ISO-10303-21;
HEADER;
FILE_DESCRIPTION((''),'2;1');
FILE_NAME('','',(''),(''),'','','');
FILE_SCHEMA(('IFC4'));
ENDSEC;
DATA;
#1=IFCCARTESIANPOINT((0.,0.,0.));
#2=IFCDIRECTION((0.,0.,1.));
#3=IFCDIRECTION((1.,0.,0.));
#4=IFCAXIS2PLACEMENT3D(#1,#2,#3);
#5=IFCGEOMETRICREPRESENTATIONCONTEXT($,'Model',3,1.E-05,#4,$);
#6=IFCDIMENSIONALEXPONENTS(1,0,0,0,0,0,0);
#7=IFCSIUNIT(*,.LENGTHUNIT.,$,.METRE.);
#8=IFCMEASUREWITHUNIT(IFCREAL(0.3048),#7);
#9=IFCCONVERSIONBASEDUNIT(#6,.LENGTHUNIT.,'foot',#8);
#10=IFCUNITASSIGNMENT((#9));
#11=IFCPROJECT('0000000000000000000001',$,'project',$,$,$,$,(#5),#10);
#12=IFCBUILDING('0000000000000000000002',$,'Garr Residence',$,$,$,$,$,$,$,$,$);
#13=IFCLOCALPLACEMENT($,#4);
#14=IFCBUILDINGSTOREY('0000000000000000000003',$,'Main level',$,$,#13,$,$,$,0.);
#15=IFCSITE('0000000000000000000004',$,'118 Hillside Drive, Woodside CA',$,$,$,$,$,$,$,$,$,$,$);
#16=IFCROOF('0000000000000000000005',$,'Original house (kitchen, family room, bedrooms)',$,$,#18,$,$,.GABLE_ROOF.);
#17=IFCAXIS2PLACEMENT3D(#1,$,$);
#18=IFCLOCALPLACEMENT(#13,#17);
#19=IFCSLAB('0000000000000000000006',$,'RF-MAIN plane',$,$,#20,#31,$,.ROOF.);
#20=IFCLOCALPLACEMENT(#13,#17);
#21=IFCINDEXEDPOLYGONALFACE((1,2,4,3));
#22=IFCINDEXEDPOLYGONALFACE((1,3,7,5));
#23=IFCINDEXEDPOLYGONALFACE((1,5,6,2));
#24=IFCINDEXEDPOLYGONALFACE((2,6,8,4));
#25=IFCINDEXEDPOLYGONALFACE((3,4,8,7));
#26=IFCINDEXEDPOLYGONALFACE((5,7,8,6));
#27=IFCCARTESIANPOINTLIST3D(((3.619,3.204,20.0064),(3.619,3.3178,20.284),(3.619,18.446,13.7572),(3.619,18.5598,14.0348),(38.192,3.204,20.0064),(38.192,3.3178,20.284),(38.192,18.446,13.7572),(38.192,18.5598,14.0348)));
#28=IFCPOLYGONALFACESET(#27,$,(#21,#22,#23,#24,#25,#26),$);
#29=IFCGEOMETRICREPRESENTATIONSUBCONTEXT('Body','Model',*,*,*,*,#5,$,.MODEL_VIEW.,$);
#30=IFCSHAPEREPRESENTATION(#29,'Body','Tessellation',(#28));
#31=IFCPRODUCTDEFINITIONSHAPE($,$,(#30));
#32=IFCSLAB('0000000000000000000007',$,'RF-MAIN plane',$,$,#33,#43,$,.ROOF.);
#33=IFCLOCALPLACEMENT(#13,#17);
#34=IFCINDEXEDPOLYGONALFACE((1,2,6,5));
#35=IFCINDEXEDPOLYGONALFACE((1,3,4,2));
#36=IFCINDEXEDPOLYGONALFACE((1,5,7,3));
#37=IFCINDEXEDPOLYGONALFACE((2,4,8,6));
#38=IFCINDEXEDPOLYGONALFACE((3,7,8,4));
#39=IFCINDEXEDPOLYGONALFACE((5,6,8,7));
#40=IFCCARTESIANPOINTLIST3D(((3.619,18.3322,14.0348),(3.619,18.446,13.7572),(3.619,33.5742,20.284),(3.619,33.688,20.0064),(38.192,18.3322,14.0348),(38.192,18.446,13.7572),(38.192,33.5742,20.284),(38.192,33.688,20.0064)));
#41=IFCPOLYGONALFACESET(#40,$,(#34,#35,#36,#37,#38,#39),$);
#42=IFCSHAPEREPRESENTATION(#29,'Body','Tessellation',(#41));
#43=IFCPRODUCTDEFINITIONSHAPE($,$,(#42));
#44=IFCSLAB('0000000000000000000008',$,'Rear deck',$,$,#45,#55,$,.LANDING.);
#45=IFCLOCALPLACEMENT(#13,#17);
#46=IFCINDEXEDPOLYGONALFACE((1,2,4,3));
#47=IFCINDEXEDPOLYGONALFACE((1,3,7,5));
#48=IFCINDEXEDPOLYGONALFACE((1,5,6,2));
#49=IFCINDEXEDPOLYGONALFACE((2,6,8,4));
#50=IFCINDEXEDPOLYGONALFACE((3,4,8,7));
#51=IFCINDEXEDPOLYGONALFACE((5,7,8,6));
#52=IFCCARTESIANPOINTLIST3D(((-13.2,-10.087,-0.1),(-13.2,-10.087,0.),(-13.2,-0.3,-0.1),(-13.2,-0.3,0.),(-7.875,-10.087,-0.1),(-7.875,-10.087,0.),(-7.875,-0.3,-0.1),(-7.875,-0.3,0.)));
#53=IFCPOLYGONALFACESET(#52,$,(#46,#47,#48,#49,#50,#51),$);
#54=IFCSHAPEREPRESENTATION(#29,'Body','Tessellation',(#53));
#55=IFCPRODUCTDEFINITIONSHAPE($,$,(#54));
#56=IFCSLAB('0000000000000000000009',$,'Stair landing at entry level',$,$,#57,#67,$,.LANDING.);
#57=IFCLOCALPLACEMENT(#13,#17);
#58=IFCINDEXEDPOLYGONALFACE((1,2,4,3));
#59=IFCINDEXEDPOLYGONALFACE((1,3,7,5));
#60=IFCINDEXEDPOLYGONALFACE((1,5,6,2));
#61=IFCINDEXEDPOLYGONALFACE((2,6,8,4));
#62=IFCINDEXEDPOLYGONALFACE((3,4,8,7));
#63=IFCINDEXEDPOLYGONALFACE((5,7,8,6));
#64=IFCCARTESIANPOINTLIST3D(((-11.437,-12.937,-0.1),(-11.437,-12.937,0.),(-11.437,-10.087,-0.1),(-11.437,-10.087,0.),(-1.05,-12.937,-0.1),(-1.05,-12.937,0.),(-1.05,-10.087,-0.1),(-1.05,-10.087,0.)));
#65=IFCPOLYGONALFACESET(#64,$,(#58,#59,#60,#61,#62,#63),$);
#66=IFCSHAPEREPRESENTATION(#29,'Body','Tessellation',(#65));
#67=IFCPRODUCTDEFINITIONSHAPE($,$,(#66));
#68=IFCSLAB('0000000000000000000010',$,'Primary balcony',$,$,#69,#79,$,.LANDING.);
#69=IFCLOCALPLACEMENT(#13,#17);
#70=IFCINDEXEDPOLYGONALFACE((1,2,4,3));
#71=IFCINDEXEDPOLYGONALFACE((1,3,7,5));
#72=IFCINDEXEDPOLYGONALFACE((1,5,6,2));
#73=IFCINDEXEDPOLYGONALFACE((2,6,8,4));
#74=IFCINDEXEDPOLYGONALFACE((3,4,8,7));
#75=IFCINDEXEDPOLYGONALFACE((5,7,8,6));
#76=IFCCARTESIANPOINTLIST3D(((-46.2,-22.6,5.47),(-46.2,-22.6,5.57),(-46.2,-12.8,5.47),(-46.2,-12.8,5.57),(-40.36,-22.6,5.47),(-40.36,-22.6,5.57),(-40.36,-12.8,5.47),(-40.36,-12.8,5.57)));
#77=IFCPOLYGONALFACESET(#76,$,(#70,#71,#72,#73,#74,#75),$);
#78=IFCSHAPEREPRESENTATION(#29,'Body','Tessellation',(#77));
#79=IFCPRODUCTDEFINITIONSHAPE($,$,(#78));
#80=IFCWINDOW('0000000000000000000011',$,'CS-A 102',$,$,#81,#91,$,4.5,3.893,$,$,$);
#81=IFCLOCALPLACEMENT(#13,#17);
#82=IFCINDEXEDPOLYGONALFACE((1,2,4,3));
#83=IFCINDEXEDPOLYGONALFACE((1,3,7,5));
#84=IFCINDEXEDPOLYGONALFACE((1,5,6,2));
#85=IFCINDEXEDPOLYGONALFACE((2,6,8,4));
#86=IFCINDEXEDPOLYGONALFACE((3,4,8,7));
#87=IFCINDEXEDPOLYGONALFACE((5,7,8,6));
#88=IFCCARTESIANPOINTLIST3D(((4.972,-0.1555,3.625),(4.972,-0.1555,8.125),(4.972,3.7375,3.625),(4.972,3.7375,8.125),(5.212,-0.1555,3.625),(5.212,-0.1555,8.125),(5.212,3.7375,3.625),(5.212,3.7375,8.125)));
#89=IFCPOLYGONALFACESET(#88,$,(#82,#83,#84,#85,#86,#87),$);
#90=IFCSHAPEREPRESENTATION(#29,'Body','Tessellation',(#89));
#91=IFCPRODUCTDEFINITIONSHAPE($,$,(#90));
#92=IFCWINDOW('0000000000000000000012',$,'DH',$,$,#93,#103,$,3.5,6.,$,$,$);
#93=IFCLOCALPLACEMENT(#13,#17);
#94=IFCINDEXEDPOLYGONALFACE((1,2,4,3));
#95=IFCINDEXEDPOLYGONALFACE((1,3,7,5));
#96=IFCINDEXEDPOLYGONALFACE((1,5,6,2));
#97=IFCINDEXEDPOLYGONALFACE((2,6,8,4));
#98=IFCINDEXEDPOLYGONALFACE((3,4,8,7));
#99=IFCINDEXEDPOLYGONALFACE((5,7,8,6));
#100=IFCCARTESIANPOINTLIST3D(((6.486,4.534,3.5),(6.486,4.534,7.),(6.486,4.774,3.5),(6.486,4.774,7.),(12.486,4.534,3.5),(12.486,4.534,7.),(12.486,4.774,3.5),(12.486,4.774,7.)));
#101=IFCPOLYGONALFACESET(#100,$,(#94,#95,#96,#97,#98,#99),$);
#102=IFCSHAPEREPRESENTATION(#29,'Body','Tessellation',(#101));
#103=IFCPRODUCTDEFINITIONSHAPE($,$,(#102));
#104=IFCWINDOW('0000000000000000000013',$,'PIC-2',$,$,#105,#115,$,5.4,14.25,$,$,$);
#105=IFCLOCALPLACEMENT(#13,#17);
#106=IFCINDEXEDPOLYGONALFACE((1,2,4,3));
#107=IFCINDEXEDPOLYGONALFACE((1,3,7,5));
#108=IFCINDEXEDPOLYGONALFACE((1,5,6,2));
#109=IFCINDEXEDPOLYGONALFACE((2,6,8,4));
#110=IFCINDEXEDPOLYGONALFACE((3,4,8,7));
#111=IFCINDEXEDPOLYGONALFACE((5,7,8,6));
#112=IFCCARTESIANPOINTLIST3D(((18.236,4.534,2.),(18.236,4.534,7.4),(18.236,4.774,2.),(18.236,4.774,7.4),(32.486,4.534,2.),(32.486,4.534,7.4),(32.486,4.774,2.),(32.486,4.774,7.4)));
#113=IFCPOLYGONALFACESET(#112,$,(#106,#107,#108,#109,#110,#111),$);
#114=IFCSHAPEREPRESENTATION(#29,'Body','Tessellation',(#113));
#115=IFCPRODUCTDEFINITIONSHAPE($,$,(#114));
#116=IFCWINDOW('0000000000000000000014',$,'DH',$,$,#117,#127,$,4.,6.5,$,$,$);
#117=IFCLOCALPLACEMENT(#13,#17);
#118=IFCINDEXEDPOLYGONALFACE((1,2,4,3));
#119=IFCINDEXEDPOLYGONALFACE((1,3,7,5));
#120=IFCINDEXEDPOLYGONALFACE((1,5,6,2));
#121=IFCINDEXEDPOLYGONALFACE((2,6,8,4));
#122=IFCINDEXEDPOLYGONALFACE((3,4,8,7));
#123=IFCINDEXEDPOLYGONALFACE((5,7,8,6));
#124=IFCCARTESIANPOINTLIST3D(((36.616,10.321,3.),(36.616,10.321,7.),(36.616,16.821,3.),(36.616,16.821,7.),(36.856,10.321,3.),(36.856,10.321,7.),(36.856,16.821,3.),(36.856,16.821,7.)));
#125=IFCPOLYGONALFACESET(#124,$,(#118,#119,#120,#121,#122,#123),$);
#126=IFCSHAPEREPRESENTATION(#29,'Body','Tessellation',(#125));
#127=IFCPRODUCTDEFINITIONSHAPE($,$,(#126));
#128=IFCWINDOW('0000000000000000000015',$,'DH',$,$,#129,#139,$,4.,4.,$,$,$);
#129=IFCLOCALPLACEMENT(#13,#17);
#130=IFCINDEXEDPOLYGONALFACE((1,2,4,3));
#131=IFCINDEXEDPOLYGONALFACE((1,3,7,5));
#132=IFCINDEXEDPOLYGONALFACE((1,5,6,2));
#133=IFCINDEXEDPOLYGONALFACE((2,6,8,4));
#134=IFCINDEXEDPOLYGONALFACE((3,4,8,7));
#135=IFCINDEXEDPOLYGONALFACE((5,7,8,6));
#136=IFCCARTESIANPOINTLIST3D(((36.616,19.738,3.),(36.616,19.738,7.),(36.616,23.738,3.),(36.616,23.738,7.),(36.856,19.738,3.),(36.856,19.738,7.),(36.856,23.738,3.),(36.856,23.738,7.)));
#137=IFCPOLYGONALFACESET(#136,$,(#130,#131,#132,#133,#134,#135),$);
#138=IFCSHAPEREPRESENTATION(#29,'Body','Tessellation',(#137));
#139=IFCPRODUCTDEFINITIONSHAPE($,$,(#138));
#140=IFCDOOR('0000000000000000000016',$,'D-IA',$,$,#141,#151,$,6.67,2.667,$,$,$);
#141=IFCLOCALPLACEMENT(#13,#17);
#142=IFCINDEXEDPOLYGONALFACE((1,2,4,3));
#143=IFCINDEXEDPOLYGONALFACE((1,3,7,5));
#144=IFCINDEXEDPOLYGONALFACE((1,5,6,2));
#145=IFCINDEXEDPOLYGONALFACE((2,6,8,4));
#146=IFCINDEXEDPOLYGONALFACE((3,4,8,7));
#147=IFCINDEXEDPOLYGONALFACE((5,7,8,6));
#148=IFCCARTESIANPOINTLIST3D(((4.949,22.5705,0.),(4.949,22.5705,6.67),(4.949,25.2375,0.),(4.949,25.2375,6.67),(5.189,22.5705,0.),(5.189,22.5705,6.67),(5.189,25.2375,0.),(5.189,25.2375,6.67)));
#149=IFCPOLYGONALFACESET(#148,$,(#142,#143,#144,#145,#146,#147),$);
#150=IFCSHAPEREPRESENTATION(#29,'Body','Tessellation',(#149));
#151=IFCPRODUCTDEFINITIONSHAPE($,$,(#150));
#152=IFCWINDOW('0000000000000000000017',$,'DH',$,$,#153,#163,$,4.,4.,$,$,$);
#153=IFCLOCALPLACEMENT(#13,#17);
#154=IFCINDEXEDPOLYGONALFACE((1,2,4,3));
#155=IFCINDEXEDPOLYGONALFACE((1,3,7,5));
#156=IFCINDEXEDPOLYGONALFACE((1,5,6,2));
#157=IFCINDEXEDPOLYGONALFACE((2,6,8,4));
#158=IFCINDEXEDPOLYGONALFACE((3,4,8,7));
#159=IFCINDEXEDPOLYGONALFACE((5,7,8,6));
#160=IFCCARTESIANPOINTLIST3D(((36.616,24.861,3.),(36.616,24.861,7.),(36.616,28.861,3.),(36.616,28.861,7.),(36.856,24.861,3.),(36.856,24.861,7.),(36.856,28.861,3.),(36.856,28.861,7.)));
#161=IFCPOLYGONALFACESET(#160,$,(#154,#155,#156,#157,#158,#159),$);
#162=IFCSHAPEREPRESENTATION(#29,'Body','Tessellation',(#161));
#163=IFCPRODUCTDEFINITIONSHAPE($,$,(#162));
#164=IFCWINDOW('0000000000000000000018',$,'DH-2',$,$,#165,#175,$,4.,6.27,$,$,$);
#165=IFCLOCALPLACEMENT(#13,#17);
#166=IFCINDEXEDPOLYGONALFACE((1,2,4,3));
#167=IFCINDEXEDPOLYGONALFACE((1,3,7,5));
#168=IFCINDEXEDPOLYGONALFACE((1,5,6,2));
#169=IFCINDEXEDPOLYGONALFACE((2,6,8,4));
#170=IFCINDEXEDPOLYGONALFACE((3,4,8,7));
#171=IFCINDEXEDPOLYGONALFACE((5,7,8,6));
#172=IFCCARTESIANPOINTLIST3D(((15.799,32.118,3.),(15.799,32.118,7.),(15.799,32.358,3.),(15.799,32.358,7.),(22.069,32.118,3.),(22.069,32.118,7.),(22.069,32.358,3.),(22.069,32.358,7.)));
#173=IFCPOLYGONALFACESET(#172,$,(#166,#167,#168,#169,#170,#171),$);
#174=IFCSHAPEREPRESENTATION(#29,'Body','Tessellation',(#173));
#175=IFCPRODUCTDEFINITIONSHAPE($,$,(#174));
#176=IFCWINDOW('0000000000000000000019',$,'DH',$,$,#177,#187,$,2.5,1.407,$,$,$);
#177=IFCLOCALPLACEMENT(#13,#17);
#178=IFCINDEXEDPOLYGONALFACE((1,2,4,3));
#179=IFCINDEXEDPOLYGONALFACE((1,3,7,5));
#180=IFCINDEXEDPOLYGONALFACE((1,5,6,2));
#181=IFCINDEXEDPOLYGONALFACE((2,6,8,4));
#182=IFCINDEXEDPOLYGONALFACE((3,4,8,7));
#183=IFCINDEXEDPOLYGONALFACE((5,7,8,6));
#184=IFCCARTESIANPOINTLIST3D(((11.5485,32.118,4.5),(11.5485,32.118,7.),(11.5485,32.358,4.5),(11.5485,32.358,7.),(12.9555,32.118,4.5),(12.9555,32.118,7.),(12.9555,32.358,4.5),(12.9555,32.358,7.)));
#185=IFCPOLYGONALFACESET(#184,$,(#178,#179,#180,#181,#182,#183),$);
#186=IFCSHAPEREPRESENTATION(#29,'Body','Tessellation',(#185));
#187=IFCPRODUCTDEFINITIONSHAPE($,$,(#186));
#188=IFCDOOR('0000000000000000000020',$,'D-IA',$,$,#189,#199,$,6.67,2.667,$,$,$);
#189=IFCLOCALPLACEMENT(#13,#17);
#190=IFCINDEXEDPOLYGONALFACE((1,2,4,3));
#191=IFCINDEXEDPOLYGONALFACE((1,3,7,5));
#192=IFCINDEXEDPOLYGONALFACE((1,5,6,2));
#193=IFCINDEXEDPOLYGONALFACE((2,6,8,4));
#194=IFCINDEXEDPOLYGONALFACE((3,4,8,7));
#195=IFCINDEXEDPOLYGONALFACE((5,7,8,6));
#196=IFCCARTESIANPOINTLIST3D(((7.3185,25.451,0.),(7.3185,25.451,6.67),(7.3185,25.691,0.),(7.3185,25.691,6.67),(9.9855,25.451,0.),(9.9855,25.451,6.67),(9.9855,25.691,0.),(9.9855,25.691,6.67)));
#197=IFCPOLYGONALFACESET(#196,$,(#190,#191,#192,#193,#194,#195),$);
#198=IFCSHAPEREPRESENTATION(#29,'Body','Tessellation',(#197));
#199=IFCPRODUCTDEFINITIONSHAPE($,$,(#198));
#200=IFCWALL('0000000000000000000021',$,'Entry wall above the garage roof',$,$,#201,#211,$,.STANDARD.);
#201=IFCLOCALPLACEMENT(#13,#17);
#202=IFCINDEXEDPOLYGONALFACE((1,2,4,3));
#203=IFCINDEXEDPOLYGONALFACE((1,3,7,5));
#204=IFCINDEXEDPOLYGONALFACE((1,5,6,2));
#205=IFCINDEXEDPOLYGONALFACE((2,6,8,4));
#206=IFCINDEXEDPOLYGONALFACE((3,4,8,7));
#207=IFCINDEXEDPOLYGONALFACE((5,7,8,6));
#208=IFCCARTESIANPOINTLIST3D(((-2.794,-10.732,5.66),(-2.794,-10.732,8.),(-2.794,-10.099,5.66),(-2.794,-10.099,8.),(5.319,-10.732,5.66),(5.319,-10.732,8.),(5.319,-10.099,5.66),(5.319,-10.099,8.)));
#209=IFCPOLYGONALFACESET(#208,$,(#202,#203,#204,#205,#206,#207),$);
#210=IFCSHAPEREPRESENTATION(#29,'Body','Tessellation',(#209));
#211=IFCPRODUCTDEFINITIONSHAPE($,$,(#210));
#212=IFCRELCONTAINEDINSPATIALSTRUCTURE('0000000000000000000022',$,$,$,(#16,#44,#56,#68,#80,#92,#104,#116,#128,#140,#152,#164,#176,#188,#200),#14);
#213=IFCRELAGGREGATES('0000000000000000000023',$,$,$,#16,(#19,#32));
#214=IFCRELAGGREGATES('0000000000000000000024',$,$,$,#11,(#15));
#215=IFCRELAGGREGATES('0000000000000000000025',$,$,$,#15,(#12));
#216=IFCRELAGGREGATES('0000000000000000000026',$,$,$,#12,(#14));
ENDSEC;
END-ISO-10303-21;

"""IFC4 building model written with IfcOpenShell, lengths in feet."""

from ifc_helpers import new_model, entity, si_unit, converted_unit, frame, origin, origin_with_axes, place, context, subcontext, project, spatial, polyline, outline, extrude, element, aggregate, save


model = new_model("IFC4")

# Units and contexts
model_context = context("Model", 3, precision=1e-05, world=origin_with_axes())
body_context = subcontext(model_context, "Body", "Model", "MODEL_VIEW")
ifc_project = project(units=[converted_unit("LENGTHUNIT", "foot", entity("IfcReal", 0.3048), si_unit("LENGTHUNIT", "METRE"), dimensions=[1, 0, 0, 0, 0, 0, 0])], contexts=[model_context])

# Site, building, storey
site = spatial("IfcSite", under=ifc_project, Name="118 Hillside Drive, Woodside CA")
building = spatial("IfcBuilding", under=site, Name="Garr Residence")
storey_placement = place(None, origin_with_axes())
storey = spatial("IfcBuildingStorey", under=building, at=storey_placement, Name="Main level", Elevation=0.0)

# Roof, slabs
roof = element("IfcRoof", 1, inside=storey, Name="Original house (kitchen, family room, bedrooms)", PredefinedType="GABLE_ROOF")
slab_1_placement = place(None, frame((3.619, 18.446, 13.7572), z_axis=(0.0, 0.379353, 0.925252), x_axis=(1.0, 0.0, 0.0)))
slab_1 = element("IfcSlab", 2, at=slab_1_placement, Name="RF-MAIN plane", PredefinedType="ROOF", context=body_context, shape_type="SweptSolid", body=[
    extrude(outline(polyline([(0.0, 0.0), (34.573, 0.0), (34.573, -16.4734), (0.0, -16.4734), (0.0, 0.0)])), origin(), (0.0, 0.0, 1.0), 0.3),
])
slab_2_placement = place(None, frame((3.619, 18.446, 13.7572), z_axis=(0.0, -0.379353, 0.925252), x_axis=(1.0, 0.0, 0.0)))
slab_2 = element("IfcSlab", 3, at=slab_2_placement, Name="RF-MAIN plane", PredefinedType="ROOF", context=body_context, shape_type="SweptSolid", body=[
    extrude(outline(polyline([(0.0, 0.0), (34.573, 0.0), (34.573, 16.4734), (0.0, 16.4734), (0.0, 0.0)])), origin(), (0.0, 0.0, 1.0), 0.3),
])
aggregate(roof, [slab_1, slab_2])

# Slabs
slab_3_placement = place(storey_placement, frame((0.0, 0.0, -0.1), z_axis=(0.0, 0.0, 1.0), x_axis=(1.0, 0.0, 0.0)))
element("IfcSlab", 4, at=slab_3_placement, inside=storey, Name="Rear deck", PredefinedType="LANDING", context=body_context, shape_type="SweptSolid", body=[
    extrude(outline(polyline([(-13.2, -10.087), (-7.875, -10.087), (-7.875, -0.3), (-13.2, -0.3), (-13.2, -10.087)])), origin(), (0.0, 0.0, 1.0), 0.1),
])
slab_4_placement = place(storey_placement, frame((0.0, 0.0, -0.1), z_axis=(0.0, 0.0, 1.0), x_axis=(1.0, 0.0, 0.0)))
element("IfcSlab", 5, at=slab_4_placement, inside=storey, Name="Stair landing at entry level", PredefinedType="LANDING", context=body_context, shape_type="SweptSolid", body=[
    extrude(outline(polyline([(-11.437, -12.937), (-1.05, -12.937), (-1.05, -10.087), (-11.437, -10.087), (-11.437, -12.937)])), origin(), (0.0, 0.0, 1.0), 0.1),
])
slab_5_placement = place(storey_placement, frame((0.0, 0.0, 5.47), z_axis=(0.0, 0.0, 1.0), x_axis=(1.0, 0.0, 0.0)))
element("IfcSlab", 6, at=slab_5_placement, inside=storey, Name="Primary balcony", PredefinedType="LANDING", context=body_context, shape_type="SweptSolid", body=[
    extrude(outline(polyline([(-46.2, -22.6), (-40.36, -22.6), (-40.36, -12.8), (-46.2, -12.8), (-46.2, -22.6)])), origin(), (0.0, 0.0, 1.0), 0.1),
])

# Windows
window_1_placement = place(storey_placement, frame((5.092, 1.791, 3.625), z_axis=(0.0, 0.0, 1.0), x_axis=(0.0, 1.0, 0.0)))
element("IfcWindow", 7, at=window_1_placement, inside=storey, Name="CS-A 102", OverallHeight=4.5, OverallWidth=3.893, context=body_context, shape_type="SweptSolid", body=[
    extrude(outline(polyline([(-1.9465, -0.12), (1.9465, -0.12), (1.9465, 0.12), (-1.9465, 0.12), (-1.9465, -0.12)])), origin(), (0.0, 0.0, 1.0), 4.5),
])
window_2_placement = place(storey_placement, frame((9.486, 4.654, 3.5), z_axis=(0.0, 0.0, 1.0), x_axis=(1.0, 0.0, 0.0)))
element("IfcWindow", 8, at=window_2_placement, inside=storey, Name="DH", OverallHeight=3.5, OverallWidth=6.0, context=body_context, shape_type="SweptSolid", body=[
    extrude(outline(polyline([(-3.0, -0.12), (3.0, -0.12), (3.0, 0.12), (-3.0, 0.12), (-3.0, -0.12)])), origin(), (0.0, 0.0, 1.0), 3.5),
])
window_3_placement = place(storey_placement, frame((25.361, 4.654, 2.0), z_axis=(0.0, 0.0, 1.0), x_axis=(1.0, 0.0, 0.0)))
element("IfcWindow", 9, at=window_3_placement, inside=storey, Name="PIC-2", OverallHeight=5.4, OverallWidth=14.25, context=body_context, shape_type="SweptSolid", body=[
    extrude(outline(polyline([(-7.125, -0.12), (7.125, -0.12), (7.125, 0.12), (-7.125, 0.12), (-7.125, -0.12)])), origin(), (0.0, 0.0, 1.0), 5.4),
])
window_4_placement = place(storey_placement, frame((36.736, 13.571, 3.0), z_axis=(0.0, 0.0, 1.0), x_axis=(0.0, 1.0, 0.0)))
element("IfcWindow", 10, at=window_4_placement, inside=storey, Name="DH", OverallHeight=4.0, OverallWidth=6.5, context=body_context, shape_type="SweptSolid", body=[
    extrude(outline(polyline([(-3.25, -0.12), (3.25, -0.12), (3.25, 0.12), (-3.25, 0.12), (-3.25, -0.12)])), origin(), (0.0, 0.0, 1.0), 4.0),
])
window_5_placement = place(storey_placement, frame((36.736, 21.738, 3.0), z_axis=(0.0, 0.0, 1.0), x_axis=(0.0, 1.0, 0.0)))
element("IfcWindow", 11, at=window_5_placement, inside=storey, Name="DH", OverallHeight=4.0, OverallWidth=4.0, context=body_context, shape_type="SweptSolid", body=[
    extrude(outline(polyline([(-2.0, -0.12), (2.0, -0.12), (2.0, 0.12), (-2.0, 0.12), (-2.0, -0.12)])), origin(), (0.0, 0.0, 1.0), 4.0),
])

# Door
door_1_placement = place(storey_placement, frame((5.069, 23.904, 0.0), z_axis=(0.0, 0.0, 1.0), x_axis=(0.0, 1.0, 0.0)))
element("IfcDoor", 12, at=door_1_placement, inside=storey, Name="D-IA", OverallHeight=6.67, OverallWidth=2.667, context=body_context, shape_type="SweptSolid", body=[
    extrude(outline(polyline([(-1.3335, -0.12), (1.3335, -0.12), (1.3335, 0.12), (-1.3335, 0.12), (-1.3335, -0.12)])), origin(), (0.0, 0.0, 1.0), 6.67),
])

# Windows
window_6_placement = place(storey_placement, frame((36.736, 26.861, 3.0), z_axis=(0.0, 0.0, 1.0), x_axis=(0.0, 1.0, 0.0)))
element("IfcWindow", 13, at=window_6_placement, inside=storey, Name="DH", OverallHeight=4.0, OverallWidth=4.0, context=body_context, shape_type="SweptSolid", body=[
    extrude(outline(polyline([(-2.0, -0.12), (2.0, -0.12), (2.0, 0.12), (-2.0, 0.12), (-2.0, -0.12)])), origin(), (0.0, 0.0, 1.0), 4.0),
])
window_7_placement = place(storey_placement, frame((18.934, 32.238, 3.0), z_axis=(0.0, 0.0, 1.0), x_axis=(1.0, 0.0, 0.0)))
element("IfcWindow", 14, at=window_7_placement, inside=storey, Name="DH-2", OverallHeight=4.0, OverallWidth=6.27, context=body_context, shape_type="SweptSolid", body=[
    extrude(outline(polyline([(-3.135, -0.12), (3.135, -0.12), (3.135, 0.12), (-3.135, 0.12), (-3.135, -0.12)])), origin(), (0.0, 0.0, 1.0), 4.0),
])
window_8_placement = place(storey_placement, frame((12.252, 32.238, 4.5), z_axis=(0.0, 0.0, 1.0), x_axis=(1.0, 0.0, 0.0)))
element("IfcWindow", 15, at=window_8_placement, inside=storey, Name="DH", OverallHeight=2.5, OverallWidth=1.407, context=body_context, shape_type="SweptSolid", body=[
    extrude(outline(polyline([(-0.7035, -0.12), (0.7035, -0.12), (0.7035, 0.12), (-0.7035, 0.12), (-0.7035, -0.12)])), origin(), (0.0, 0.0, 1.0), 2.5),
])

# Door
door_2_placement = place(storey_placement, frame((8.652, 25.571, 0.0), z_axis=(0.0, 0.0, 1.0), x_axis=(1.0, 0.0, 0.0)))
element("IfcDoor", 16, at=door_2_placement, inside=storey, Name="D-IA", OverallHeight=6.67, OverallWidth=2.667, context=body_context, shape_type="SweptSolid", body=[
    extrude(outline(polyline([(-1.3335, -0.12), (1.3335, -0.12), (1.3335, 0.12), (-1.3335, 0.12), (-1.3335, -0.12)])), origin(), (0.0, 0.0, 1.0), 6.67),
])

# Wall
wall_placement = place(storey_placement, frame((0.0, 0.0, 5.66), z_axis=(0.0, 0.0, 1.0), x_axis=(1.0, 0.0, 0.0)))
element("IfcWall", 17, at=wall_placement, inside=storey, Name="Entry wall above the garage roof", PredefinedType="STANDARD", context=body_context, shape_type="SweptSolid", body=[
    extrude(outline(polyline([(-2.794, -10.732), (5.319, -10.732), (5.319, -10.099), (-2.794, -10.099), (-2.794, -10.732)])), origin(), (0.0, 0.0, 1.0), 2.34),
])

save(model, "model.ifc")
